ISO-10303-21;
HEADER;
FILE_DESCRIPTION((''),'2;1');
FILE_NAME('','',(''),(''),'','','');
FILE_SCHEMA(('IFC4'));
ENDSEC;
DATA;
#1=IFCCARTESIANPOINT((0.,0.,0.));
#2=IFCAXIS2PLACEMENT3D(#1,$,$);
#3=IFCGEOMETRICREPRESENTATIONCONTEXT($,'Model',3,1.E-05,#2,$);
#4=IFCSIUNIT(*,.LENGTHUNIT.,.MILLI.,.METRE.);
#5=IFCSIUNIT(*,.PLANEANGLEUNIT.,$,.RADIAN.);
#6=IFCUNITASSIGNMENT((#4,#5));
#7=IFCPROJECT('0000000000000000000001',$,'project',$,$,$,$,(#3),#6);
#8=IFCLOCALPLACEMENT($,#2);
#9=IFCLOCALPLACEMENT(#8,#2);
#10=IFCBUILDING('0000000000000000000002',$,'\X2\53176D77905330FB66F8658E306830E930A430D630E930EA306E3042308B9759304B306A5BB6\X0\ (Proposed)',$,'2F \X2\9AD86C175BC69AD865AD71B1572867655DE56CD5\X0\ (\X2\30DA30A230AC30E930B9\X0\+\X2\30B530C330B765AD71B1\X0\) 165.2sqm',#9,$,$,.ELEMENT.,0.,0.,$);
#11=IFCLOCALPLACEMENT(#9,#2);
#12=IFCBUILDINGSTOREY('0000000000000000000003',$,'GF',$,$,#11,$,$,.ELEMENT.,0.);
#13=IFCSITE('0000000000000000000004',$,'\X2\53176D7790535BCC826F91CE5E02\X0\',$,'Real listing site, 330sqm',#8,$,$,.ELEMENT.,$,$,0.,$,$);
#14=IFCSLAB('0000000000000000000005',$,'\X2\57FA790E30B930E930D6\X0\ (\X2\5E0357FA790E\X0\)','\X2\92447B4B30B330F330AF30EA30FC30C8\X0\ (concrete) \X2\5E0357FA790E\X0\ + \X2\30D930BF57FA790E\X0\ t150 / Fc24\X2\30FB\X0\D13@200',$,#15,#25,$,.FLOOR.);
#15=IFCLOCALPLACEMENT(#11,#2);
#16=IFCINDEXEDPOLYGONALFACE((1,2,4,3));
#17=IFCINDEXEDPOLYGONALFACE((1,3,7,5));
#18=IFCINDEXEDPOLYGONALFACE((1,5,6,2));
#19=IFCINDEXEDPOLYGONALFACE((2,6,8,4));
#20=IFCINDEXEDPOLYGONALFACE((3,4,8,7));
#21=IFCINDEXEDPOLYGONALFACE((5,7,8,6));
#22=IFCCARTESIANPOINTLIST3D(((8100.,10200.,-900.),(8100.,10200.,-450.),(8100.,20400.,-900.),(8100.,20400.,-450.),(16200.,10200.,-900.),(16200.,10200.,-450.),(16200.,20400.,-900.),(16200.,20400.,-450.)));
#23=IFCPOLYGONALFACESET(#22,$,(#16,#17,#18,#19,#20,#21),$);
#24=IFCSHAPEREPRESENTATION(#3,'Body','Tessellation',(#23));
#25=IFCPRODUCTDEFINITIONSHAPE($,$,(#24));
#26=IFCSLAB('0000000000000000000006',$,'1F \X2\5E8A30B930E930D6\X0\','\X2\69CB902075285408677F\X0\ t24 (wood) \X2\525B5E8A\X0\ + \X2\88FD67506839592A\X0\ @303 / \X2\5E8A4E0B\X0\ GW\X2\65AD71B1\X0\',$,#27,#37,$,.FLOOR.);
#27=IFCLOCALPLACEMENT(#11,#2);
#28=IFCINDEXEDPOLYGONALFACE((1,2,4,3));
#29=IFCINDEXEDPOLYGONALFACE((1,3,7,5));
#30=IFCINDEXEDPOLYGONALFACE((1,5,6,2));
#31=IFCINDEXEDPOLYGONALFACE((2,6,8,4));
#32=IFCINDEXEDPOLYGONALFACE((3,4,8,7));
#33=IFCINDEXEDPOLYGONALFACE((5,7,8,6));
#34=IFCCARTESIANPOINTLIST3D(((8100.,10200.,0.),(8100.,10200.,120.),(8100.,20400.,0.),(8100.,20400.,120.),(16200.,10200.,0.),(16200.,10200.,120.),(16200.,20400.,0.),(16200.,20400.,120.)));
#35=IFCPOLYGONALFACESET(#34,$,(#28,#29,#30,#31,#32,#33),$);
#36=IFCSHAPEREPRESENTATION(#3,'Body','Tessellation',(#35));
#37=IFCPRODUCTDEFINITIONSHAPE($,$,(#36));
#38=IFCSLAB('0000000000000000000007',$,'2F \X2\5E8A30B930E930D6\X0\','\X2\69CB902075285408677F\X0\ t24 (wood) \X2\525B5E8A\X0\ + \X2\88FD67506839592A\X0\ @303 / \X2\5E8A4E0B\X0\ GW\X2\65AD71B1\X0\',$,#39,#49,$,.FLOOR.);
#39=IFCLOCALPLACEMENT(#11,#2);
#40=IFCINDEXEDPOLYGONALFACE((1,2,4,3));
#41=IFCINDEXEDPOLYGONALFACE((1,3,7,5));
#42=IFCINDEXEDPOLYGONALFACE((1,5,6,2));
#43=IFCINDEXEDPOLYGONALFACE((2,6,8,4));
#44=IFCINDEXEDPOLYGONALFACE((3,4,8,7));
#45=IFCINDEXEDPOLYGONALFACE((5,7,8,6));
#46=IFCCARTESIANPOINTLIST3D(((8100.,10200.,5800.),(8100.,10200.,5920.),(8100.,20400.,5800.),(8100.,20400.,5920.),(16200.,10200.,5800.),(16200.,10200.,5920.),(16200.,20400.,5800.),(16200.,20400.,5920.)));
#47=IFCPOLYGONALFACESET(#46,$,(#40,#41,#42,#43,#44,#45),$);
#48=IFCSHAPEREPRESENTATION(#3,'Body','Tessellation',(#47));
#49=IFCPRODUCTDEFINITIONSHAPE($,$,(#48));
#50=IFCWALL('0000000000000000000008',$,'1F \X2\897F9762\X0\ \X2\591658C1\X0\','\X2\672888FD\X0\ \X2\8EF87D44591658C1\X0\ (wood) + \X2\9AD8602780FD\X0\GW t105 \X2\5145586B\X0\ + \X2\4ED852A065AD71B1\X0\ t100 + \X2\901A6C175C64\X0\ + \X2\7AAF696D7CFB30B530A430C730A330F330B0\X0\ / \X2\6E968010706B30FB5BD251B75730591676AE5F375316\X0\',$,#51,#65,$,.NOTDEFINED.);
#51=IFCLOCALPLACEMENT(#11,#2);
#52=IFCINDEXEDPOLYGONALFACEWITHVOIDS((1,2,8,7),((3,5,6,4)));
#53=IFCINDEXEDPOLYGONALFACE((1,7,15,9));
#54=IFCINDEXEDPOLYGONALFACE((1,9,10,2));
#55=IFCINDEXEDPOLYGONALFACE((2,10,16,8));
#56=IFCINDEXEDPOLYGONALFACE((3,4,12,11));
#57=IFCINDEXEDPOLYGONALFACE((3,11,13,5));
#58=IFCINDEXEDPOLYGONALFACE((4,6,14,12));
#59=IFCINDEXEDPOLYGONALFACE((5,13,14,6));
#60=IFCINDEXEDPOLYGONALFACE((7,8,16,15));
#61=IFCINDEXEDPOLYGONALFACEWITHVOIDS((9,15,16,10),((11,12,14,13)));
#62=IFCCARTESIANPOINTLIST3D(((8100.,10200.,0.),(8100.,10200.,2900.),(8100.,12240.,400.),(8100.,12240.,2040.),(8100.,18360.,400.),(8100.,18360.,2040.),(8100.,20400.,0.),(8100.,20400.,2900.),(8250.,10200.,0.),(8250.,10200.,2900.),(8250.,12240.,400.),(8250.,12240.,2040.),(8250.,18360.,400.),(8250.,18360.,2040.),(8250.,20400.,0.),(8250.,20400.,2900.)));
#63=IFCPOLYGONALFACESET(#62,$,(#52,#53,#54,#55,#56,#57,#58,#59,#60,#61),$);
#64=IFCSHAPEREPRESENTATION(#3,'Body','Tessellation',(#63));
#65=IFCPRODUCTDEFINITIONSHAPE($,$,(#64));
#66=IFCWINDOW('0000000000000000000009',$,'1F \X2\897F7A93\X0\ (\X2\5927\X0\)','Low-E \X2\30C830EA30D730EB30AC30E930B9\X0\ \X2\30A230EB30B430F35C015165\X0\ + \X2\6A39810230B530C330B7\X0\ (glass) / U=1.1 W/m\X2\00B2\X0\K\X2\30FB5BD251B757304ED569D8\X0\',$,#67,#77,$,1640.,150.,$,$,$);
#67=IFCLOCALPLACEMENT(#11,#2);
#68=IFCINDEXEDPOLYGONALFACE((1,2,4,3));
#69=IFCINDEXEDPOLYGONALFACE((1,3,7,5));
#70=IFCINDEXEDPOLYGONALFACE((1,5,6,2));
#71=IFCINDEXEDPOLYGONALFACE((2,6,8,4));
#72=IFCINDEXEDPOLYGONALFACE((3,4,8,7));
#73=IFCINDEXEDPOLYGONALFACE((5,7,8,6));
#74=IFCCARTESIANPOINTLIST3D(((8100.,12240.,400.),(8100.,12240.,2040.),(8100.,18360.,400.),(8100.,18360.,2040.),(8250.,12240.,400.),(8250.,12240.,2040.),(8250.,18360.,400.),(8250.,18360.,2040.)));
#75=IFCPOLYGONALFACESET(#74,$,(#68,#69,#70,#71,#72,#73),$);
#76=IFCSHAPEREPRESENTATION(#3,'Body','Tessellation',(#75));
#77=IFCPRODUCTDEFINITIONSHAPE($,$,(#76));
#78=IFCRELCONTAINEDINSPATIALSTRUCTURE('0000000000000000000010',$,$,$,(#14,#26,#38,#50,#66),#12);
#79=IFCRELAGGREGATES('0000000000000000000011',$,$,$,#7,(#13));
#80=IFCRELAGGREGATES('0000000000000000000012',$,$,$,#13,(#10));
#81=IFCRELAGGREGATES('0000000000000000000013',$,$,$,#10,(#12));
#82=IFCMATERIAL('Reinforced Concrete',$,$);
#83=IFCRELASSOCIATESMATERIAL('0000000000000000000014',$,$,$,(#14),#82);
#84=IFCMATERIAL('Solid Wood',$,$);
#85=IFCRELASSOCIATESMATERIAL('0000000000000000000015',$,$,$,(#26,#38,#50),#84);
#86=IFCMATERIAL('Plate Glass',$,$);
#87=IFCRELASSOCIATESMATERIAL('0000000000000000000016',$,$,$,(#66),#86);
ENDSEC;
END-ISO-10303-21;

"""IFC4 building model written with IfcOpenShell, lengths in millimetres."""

from ifc_helpers import new_model, si_unit, frame, frame_2d, origin, place, context, project, spatial, rectangle, extrude, material, element, fill, save


model = new_model("IFC4")

# Units and contexts
model_context = context("Model", 3, precision=1e-05, world=origin())
ifc_project = project(units=[si_unit("LENGTHUNIT", "METRE", prefix="MILLI"), si_unit("PLANEANGLEUNIT", "RADIAN")], contexts=[model_context])

# Site, building, storey
site_placement = place(None, origin())
site = spatial("IfcSite", under=ifc_project, at=site_placement, Name="北海道富良野市", ObjectType="Real listing site, 330sqm", CompositionType="ELEMENT", RefElevation=0.0)
building_placement = place(site_placement, origin())
building = spatial("IfcBuilding", under=site, at=building_placement, Name="北海道・書斎とライブラリのある静かな家 (Proposed)", ObjectType="2F 高気密高断熱在来工法 (ペアガラス+サッシ断熱) 165.2sqm", CompositionType="ELEMENT", ElevationOfRefHeight=0.0, ElevationOfTerrain=0.0)
storey_placement = place(building_placement, origin())
storey = spatial("IfcBuildingStorey", under=building, at=storey_placement, Name="GF", CompositionType="ELEMENT", Elevation=0.0)

# Shared definitions
ifc_material_1 = material(Name="Solid Wood")

# Slabs
ifc_material_2 = material(Name="Reinforced Concrete")
slab_1_placement = place(storey_placement, frame((4050.0, 5100.0, -450.0)))
element("IfcSlab", 1, at=slab_1_placement, inside=storey, material=ifc_material_2, Name="基礎スラブ (布基礎)", Description="鉄筋コンクリート (concrete) 布基礎 + ベタ基礎 t150 / Fc24・D13@200", PredefinedType="FLOOR", context=model_context, shape_type="SweptSolid", body=[
    extrude(rectangle(XDim=8100.0, YDim=10200.0, at=frame_2d((4050.0, 5100.0))), frame((4050.0, 5100.0, -450.0)), (0.0, 0.0, 1.0), 450.0),
])
slab_2_placement = place(storey_placement, frame((4050.0, 5100.0, 0.0)))
element("IfcSlab", 2, at=slab_2_placement, inside=storey, material=ifc_material_1, Name="1F 床スラブ", Description="構造用合板 t24 (wood) 剛床 + 製材根太 @303 / 床下 GW断熱", PredefinedType="FLOOR", context=model_context, shape_type="SweptSolid", body=[
    extrude(rectangle(XDim=8100.0, YDim=10200.0, at=frame_2d((4050.0, 5100.0))), frame((4050.0, 5100.0, 0.0)), (0.0, 0.0, 1.0), 120.0),
])
slab_3_placement = place(storey_placement, frame((4050.0, 5100.0, 2900.0)))
element("IfcSlab", 3, at=slab_3_placement, inside=storey, material=ifc_material_1, Name="2F 床スラブ", Description="構造用合板 t24 (wood) 剛床 + 製材根太 @303 / 床下 GW断熱", PredefinedType="FLOOR", context=model_context, shape_type="SweptSolid", body=[
    extrude(rectangle(XDim=8100.0, YDim=10200.0, at=frame_2d((4050.0, 5100.0))), frame((4050.0, 5100.0, 2900.0)), (0.0, 0.0, 1.0), 120.0),
])

# Shared definitions
ifc_material_3 = material(Name="Plate Glass")

# Wall, opening, window
wall_1_placement = place(storey_placement, frame((4050.0, 5100.0, 0.0)))
wall_1 = element("IfcWall", 4, at=wall_1_placement, inside=storey, material=ifc_material_1, Name="1F 西面 外壁", Description="木製 軸組外壁 (wood) + 高性能GW t105 充填 + 付加断熱 t100 + 通気層 + 窯業系サイディング / 準耐火・寒冷地外皮強化", PredefinedType="NOTDEFINED", context=model_context, shape_type="SweptSolid", body=[
    extrude(rectangle(XDim=150.0, YDim=10200.0, at=frame_2d((75.0, 5100.0))), frame((4050.0, 5100.0, 0.0)), (0.0, 0.0, 1.0), 2900.0),
])
opening_1_placement = place(storey_placement, frame((4050.0, 6120.0, 200.0)))
opening_1 = element("IfcOpeningElement", 5, at=opening_1_placement, cuts=wall_1, PredefinedType="NOTDEFINED", context=model_context, shape_type="SweptSolid", body=[
    extrude(rectangle(XDim=150.0, YDim=6120.0, at=frame_2d((75.0, 3060.0))), frame((4050.0, 6120.0, 200.0)), (0.0, 0.0, 1.0), 1640.0),
])
window_1_placement = place(storey_placement, frame((4050.0, 6120.0, 200.0)))
window_1 = element("IfcWindow", 6, at=window_1_placement, inside=storey, material=ifc_material_3, Name="1F 西窓 (大)", Description="Low-E トリプルガラス アルゴン封入 + 樹脂サッシ (glass) / U=1.1 W/m²K・寒冷地仕様", OverallHeight=1640.0, OverallWidth=150.0, context=model_context, shape_type="SweptSolid", body=[
    extrude(rectangle(XDim=150.0, YDim=6120.0, at=frame_2d((75.0, 3060.0))), frame((4050.0, 6120.0, 200.0)), (0.0, 0.0, 1.0), 1640.0),
])
fill(opening_1, window_1)

save(model, "model.ifc")
